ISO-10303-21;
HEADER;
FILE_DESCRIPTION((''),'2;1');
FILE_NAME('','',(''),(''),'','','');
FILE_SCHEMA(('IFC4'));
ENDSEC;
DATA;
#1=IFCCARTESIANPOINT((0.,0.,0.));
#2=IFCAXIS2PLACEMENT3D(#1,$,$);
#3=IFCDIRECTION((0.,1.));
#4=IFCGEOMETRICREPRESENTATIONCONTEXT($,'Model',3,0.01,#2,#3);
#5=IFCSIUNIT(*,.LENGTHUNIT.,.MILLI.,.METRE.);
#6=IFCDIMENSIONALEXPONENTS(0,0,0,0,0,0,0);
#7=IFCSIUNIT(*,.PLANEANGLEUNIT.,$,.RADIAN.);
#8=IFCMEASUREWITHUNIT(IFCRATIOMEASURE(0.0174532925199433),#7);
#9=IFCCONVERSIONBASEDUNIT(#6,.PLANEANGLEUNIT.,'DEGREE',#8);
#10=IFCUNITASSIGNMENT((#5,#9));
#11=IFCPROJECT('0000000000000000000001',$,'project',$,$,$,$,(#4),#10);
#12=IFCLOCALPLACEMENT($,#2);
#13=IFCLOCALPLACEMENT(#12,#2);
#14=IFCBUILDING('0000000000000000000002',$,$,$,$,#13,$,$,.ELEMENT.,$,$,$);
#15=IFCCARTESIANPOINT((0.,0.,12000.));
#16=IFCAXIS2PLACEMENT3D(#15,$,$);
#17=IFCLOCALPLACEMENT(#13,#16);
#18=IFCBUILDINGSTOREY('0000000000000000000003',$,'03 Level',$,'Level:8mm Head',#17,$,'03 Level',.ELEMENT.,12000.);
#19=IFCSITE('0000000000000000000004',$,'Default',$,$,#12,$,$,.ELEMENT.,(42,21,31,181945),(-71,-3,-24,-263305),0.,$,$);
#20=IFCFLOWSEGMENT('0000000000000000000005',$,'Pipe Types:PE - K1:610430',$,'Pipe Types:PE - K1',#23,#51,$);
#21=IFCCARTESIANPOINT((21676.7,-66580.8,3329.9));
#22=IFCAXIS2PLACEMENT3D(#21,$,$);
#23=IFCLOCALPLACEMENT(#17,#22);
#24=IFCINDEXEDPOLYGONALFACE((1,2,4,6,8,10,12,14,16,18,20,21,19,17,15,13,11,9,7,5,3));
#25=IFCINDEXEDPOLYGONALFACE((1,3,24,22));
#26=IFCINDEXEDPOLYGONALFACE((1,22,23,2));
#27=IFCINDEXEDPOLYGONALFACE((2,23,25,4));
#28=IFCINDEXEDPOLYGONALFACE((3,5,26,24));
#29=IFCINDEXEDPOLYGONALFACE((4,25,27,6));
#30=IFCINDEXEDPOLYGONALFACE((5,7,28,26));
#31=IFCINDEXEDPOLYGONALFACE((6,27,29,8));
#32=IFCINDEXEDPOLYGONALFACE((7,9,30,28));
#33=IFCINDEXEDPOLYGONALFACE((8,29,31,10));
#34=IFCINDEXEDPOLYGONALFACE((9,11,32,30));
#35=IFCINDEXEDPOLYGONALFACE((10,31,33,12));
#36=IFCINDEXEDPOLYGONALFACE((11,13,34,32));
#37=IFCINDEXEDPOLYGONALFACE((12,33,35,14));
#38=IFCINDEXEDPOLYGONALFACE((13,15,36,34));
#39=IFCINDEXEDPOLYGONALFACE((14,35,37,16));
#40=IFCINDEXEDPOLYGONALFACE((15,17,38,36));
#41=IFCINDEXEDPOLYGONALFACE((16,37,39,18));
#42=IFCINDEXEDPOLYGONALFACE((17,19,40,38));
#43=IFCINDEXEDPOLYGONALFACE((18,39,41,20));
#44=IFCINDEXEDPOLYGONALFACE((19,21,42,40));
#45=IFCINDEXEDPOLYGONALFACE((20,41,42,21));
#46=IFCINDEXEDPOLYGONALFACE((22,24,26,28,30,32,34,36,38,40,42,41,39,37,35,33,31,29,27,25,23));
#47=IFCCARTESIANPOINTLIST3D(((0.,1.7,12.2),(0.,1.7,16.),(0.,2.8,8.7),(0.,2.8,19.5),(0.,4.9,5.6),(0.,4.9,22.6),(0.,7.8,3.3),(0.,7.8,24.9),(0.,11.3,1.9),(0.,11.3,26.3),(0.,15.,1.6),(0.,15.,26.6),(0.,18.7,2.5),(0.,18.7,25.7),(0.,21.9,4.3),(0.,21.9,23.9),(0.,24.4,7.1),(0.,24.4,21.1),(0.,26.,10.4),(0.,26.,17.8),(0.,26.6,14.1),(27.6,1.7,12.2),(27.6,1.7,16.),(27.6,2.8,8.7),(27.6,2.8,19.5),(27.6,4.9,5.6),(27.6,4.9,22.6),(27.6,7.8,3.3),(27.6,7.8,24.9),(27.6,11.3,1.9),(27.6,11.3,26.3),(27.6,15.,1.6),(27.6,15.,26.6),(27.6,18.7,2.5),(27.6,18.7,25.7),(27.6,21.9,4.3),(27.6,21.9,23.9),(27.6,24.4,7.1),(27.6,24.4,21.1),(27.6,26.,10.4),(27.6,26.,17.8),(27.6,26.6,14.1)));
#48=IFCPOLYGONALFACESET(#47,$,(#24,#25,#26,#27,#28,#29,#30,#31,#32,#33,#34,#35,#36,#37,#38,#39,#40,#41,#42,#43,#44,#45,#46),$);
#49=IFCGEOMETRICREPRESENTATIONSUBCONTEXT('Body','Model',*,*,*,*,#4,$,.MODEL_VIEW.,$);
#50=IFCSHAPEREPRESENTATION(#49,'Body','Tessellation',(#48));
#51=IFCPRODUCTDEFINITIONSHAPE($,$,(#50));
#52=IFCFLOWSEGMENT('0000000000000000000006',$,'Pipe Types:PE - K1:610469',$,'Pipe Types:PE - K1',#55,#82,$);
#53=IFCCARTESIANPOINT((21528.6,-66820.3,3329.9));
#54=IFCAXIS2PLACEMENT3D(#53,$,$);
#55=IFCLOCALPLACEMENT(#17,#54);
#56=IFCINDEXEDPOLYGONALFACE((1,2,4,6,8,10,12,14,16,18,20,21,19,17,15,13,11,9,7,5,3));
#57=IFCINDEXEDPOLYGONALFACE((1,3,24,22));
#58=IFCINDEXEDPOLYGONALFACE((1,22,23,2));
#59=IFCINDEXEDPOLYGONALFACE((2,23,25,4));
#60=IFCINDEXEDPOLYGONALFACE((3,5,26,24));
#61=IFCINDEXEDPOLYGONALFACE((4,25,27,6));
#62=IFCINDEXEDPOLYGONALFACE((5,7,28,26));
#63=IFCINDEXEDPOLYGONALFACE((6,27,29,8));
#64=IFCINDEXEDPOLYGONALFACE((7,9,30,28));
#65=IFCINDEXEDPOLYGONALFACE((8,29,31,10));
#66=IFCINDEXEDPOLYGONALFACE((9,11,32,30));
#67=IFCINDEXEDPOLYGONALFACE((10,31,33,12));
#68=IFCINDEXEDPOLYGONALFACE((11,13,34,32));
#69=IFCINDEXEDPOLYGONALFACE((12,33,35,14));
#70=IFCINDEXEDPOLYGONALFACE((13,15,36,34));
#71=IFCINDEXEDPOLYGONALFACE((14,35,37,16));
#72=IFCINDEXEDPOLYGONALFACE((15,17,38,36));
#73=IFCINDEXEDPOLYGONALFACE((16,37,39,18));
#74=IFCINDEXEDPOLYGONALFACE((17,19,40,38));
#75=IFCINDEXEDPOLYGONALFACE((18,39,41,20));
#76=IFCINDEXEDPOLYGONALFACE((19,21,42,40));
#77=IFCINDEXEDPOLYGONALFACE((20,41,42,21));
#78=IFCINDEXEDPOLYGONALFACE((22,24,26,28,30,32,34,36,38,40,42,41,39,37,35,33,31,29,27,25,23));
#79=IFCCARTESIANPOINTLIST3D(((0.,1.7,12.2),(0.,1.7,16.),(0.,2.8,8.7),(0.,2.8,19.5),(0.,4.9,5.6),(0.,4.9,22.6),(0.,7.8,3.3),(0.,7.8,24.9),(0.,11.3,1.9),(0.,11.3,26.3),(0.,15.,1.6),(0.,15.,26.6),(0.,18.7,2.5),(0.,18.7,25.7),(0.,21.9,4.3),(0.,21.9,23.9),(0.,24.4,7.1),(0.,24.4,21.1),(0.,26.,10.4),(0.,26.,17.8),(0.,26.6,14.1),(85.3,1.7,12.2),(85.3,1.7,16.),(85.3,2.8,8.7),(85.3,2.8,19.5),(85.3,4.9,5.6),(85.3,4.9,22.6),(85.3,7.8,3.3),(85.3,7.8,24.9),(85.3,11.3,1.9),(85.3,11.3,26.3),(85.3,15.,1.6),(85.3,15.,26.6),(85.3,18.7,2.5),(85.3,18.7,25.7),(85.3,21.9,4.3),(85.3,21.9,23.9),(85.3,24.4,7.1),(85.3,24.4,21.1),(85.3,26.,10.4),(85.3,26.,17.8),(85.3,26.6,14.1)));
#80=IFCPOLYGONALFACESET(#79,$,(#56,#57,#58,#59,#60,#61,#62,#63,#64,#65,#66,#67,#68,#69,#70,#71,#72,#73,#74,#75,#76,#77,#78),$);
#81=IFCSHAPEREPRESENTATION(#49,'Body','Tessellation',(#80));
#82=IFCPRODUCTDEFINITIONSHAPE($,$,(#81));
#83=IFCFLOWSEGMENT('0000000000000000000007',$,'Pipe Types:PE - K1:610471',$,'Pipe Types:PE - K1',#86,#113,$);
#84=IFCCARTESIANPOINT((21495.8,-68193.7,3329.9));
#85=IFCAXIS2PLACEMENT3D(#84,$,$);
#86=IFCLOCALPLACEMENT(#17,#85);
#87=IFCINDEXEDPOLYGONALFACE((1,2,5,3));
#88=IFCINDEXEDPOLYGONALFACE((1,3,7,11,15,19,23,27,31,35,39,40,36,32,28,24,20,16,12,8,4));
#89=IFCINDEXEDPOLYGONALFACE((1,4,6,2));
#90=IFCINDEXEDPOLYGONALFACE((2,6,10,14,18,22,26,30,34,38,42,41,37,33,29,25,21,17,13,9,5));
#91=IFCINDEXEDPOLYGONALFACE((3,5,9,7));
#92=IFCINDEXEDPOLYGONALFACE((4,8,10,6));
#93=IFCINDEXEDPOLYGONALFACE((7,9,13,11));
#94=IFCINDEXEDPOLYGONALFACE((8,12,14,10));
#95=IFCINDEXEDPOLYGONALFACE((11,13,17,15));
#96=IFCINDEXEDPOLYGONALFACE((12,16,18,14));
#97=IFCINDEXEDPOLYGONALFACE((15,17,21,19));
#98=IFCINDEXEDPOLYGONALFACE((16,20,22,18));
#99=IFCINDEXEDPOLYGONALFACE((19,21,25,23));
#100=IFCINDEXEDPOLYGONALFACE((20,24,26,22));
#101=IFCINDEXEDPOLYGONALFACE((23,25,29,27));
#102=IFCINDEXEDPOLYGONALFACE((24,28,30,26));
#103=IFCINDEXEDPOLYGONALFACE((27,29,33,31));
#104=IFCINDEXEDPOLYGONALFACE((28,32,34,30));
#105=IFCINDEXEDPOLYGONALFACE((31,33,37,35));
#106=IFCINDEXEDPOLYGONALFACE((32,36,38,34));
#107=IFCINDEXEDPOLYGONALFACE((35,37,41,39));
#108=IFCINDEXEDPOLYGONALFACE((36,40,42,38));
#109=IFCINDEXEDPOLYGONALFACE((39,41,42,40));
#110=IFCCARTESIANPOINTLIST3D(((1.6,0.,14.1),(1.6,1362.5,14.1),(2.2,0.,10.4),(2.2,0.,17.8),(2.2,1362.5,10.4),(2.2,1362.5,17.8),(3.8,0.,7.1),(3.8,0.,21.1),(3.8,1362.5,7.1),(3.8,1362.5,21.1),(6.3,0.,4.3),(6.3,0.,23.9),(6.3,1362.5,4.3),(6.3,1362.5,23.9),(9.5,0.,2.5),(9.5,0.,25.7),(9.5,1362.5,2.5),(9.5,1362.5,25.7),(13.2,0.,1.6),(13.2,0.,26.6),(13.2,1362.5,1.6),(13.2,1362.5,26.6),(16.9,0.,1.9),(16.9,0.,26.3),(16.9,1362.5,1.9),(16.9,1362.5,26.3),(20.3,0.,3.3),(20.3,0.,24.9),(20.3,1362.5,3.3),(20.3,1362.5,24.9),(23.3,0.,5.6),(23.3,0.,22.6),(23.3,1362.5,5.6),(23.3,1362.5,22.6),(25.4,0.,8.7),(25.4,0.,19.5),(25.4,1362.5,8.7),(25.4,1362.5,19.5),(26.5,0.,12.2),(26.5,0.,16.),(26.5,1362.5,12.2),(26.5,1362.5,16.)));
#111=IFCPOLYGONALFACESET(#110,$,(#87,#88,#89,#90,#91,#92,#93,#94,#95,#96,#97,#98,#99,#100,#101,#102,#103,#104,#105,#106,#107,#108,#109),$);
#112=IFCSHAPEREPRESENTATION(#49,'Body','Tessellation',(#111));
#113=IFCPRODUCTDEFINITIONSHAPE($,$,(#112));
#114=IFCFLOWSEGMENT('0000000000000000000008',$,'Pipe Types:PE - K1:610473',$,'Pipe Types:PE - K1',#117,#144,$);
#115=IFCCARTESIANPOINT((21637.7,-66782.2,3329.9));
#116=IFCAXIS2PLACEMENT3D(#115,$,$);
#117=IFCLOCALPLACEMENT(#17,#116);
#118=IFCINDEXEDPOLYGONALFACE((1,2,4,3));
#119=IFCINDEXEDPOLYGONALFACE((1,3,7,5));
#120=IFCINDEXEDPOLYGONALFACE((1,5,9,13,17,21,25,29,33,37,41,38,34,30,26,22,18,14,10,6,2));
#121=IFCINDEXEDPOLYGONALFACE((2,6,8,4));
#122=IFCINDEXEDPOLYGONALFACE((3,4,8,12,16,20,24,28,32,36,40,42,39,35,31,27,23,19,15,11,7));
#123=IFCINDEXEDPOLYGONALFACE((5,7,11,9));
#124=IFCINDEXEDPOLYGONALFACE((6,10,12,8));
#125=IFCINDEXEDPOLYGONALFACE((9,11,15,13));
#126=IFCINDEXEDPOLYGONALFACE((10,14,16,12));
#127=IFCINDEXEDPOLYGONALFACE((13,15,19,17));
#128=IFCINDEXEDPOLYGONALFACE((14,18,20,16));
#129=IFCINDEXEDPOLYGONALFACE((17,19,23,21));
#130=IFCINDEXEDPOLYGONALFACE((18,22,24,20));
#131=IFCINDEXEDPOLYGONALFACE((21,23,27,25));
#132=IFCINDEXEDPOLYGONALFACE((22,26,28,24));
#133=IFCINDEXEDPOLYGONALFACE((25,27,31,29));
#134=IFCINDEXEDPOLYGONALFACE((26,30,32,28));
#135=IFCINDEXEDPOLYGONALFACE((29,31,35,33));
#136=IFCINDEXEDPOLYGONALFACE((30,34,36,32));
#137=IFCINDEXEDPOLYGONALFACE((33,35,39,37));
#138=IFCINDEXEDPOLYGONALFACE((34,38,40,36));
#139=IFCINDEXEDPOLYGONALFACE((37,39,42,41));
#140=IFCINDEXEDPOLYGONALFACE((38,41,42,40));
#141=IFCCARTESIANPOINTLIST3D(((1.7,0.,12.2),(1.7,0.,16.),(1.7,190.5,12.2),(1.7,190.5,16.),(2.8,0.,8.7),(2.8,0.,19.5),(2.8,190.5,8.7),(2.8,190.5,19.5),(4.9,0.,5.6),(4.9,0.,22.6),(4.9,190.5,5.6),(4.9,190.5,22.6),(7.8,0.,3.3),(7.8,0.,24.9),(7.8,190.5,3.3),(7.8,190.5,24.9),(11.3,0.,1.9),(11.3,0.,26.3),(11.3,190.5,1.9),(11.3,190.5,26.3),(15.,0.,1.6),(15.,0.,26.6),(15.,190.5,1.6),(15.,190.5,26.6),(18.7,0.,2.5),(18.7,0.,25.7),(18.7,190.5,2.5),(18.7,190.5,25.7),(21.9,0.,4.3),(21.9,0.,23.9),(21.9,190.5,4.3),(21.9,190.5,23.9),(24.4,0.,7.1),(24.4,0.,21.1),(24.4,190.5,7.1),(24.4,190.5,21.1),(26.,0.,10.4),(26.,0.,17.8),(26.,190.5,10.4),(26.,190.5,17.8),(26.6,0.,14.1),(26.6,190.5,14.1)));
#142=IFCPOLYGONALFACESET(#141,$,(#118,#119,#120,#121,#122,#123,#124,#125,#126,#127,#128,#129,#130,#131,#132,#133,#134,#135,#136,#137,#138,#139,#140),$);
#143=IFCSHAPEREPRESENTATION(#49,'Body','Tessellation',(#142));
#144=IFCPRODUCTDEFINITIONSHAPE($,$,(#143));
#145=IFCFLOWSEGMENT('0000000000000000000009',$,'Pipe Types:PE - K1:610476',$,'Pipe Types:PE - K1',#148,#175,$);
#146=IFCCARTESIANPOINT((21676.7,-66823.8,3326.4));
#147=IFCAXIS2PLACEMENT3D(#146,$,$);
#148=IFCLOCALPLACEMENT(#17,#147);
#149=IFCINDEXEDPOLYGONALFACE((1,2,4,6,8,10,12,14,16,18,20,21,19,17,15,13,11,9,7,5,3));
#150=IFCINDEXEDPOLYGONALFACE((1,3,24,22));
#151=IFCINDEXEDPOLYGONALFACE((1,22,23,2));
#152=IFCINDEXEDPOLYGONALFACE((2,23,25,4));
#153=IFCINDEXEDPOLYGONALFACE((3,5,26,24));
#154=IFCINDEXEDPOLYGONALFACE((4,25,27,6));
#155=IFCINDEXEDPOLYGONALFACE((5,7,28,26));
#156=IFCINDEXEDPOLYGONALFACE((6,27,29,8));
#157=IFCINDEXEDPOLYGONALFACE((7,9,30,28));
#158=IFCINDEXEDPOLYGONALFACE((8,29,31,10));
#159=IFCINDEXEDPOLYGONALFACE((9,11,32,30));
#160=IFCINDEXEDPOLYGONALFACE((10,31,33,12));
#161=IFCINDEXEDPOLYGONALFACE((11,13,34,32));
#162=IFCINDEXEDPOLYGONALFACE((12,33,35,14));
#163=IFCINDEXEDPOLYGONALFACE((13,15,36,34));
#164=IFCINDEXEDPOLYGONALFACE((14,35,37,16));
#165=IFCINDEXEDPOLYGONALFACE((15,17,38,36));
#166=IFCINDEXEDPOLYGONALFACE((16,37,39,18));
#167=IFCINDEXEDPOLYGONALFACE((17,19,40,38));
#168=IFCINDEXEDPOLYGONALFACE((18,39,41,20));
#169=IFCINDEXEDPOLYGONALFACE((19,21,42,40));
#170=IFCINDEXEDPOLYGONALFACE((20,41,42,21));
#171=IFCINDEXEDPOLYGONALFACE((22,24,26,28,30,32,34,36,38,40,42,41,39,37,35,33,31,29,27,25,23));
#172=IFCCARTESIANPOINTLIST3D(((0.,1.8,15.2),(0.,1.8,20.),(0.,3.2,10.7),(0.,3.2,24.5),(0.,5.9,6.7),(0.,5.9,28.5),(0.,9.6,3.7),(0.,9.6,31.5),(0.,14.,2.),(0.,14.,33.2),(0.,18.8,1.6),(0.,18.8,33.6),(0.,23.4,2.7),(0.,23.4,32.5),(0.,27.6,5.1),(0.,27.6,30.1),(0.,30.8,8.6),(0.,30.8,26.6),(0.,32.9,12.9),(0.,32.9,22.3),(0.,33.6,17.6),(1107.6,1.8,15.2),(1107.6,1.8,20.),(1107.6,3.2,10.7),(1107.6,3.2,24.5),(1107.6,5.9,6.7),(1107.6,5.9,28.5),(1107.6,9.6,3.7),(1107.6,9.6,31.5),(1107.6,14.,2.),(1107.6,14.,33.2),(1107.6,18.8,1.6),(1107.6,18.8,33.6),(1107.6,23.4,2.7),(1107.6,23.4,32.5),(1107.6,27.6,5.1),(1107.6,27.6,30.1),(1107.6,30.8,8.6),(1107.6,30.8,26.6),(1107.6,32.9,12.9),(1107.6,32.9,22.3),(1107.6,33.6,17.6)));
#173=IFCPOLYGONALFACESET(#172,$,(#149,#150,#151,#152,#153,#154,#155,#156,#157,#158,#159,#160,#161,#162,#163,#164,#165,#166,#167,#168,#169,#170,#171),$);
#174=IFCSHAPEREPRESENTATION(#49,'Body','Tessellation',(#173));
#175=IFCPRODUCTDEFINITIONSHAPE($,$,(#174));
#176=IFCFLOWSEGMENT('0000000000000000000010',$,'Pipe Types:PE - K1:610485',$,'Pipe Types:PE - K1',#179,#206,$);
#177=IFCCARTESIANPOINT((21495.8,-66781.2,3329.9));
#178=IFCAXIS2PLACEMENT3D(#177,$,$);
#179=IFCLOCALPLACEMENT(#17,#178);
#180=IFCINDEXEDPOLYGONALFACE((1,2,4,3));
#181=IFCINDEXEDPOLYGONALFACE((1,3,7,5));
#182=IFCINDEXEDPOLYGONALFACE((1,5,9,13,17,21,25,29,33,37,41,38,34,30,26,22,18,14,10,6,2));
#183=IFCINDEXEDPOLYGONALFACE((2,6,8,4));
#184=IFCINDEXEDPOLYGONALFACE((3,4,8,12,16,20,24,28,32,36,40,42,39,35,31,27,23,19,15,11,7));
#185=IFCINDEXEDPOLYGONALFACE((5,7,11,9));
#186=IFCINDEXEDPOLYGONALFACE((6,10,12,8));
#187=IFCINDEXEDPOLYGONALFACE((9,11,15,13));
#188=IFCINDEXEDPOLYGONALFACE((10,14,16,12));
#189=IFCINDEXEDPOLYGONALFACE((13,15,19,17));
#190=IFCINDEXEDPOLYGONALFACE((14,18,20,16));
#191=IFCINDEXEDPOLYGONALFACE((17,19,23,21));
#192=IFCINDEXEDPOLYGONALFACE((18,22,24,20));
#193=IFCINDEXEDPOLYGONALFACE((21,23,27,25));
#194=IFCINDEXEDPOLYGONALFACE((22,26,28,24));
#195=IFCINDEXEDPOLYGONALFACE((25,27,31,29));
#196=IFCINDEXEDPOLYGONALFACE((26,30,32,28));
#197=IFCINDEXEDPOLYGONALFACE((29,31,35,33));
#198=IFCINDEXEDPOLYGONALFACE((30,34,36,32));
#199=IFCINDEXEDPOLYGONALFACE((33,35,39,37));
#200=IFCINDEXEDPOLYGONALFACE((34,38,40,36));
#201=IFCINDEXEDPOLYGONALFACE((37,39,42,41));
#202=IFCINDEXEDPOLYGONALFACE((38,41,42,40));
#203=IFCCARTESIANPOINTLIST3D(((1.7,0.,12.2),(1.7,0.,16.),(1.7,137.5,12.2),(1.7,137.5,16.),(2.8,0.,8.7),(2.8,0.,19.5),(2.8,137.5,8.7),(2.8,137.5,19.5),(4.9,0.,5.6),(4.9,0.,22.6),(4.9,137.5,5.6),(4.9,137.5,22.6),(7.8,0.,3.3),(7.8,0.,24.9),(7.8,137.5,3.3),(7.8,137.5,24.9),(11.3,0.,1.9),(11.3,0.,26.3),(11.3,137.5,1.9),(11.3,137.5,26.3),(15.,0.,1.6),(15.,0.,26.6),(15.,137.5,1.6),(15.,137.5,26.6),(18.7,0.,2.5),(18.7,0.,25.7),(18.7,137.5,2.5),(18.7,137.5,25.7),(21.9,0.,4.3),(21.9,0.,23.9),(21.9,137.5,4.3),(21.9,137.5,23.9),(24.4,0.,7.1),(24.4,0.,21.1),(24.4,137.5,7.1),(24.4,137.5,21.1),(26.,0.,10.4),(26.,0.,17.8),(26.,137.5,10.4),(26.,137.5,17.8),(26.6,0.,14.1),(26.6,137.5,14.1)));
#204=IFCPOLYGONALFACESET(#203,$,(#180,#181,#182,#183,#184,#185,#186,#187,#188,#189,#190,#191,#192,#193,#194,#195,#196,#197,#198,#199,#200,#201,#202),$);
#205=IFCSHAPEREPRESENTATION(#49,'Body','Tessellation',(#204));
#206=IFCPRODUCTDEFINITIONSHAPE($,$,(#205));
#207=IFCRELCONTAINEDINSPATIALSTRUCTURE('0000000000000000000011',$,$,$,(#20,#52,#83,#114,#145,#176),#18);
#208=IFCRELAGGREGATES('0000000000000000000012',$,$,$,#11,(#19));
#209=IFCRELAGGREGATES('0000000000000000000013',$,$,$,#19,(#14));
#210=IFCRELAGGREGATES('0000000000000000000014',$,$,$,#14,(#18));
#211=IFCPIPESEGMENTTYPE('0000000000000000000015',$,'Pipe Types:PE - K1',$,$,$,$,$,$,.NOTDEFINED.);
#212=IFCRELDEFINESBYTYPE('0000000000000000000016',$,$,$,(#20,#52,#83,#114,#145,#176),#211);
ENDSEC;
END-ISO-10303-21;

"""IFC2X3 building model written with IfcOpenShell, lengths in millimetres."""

from ifc_helpers import new_model, entity, si_unit, converted_unit, direction, frame, frame_2d, origin, origin_2d_with_axis, place, context, subcontext, project, spatial, circle, extrude, type_object, element, save


model = new_model("IFC2X3")

# Units and contexts
model_context = context("Model", 3, precision=0.01, world=origin(), true_north=direction((0.0, 1.0)))
body_context = subcontext(model_context, "Body", "Model", "MODEL_VIEW")
ifc_project = project(units=[si_unit("LENGTHUNIT", "METRE", prefix="MILLI"), converted_unit("PLANEANGLEUNIT", "DEGREE", entity("IfcRatioMeasure", 0.0174532925199433), si_unit("PLANEANGLEUNIT", "RADIAN"), dimensions=[0, 0, 0, 0, 0, 0, 0])], contexts=[model_context])

# Site, building, storey
site_placement = place(None, origin())
site = spatial("IfcSite", under=ifc_project, at=site_placement, Name="Default", CompositionType="ELEMENT", RefLatitude=(42, 21, 31, 181945), RefLongitude=(-71, -3, -24, -263305), RefElevation=0.0)
building_placement = place(site_placement, origin())
building = spatial("IfcBuilding", under=site, at=building_placement, CompositionType="ELEMENT")
storey_placement = place(building_placement, frame((0.0, 0.0, 12000.0)))
storey = spatial("IfcBuildingStorey", under=building, at=storey_placement, Name="03 Level", ObjectType="Level:8mm Head", LongName="03 Level", CompositionType="ELEMENT", Elevation=12000.0)

# Flow segments
pipe_segment_type = type_object("IfcPipeSegmentType", Name="Pipe Types:PE - K1", PredefinedType="NOTDEFINED")
flow_segment_1_placement = place(storey_placement, frame((21676.7, -66580.8, 3329.9)))
element("IfcFlowSegment", 1, at=flow_segment_1_placement, inside=storey, type_object=pipe_segment_type, Name="Pipe Types:PE - K1:610430", ObjectType="Pipe Types:PE - K1", context=body_context, shape_type="SweptSolid", body=[
    extrude(circle(Radius=12.5, at=frame_2d((0.0, 0.0), x_axis=(1.0, 0.0))), frame((0.0, 14.1, 14.1), z_axis=(1.0, 0.0, 0.0), x_axis=(0.0, 1.0, 0.0)), (0.0, 0.0, 1.0), 27.6),
])
flow_segment_2_placement = place(storey_placement, frame((21528.6, -66820.3, 3329.9)))
element("IfcFlowSegment", 2, at=flow_segment_2_placement, inside=storey, type_object=pipe_segment_type, Name="Pipe Types:PE - K1:610469", ObjectType="Pipe Types:PE - K1", context=body_context, shape_type="SweptSolid", body=[
    extrude(circle(Radius=12.5, at=origin_2d_with_axis()), frame((0.0, 14.1, 14.1), z_axis=(1.0, 0.0, 0.0), x_axis=(0.0, 1.0, 0.0)), (0.0, 0.0, 1.0), 85.3),
])
flow_segment_3_placement = place(storey_placement, frame((21495.8, -68193.7, 3329.9)))
element("IfcFlowSegment", 3, at=flow_segment_3_placement, inside=storey, type_object=pipe_segment_type, Name="Pipe Types:PE - K1:610471", ObjectType="Pipe Types:PE - K1", context=body_context, shape_type="SweptSolid", body=[
    extrude(circle(Radius=12.5, at=frame_2d((0.0, 0.0), x_axis=(1.0, 0.0))), frame((14.1, 0.0, 14.1), z_axis=(0.0, 1.0, 0.0), x_axis=(-1.0, 0.0, 0.0)), (0.0, 0.0, 1.0), 1362.5),
])
flow_segment_4_placement = place(storey_placement, frame((21637.7, -66782.2, 3329.9)))
element("IfcFlowSegment", 4, at=flow_segment_4_placement, inside=storey, type_object=pipe_segment_type, Name="Pipe Types:PE - K1:610473", ObjectType="Pipe Types:PE - K1", context=body_context, shape_type="SweptSolid", body=[
    extrude(circle(Radius=12.5, at=origin_2d_with_axis()), frame((14.1, 0.0, 14.1), z_axis=(0.0, 1.0, 0.0), x_axis=(1.0, 0.0, 0.0)), (0.0, 0.0, 1.0), 190.5),
])
flow_segment_5_placement = place(storey_placement, frame((21676.7, -66823.8, 3326.4)))
element("IfcFlowSegment", 5, at=flow_segment_5_placement, inside=storey, type_object=pipe_segment_type, Name="Pipe Types:PE - K1:610476", ObjectType="Pipe Types:PE - K1", context=body_context, shape_type="SweptSolid", body=[
    extrude(circle(Radius=16.0, at=frame_2d((0.0, 0.0), x_axis=(1.0, 0.0))), frame((0.0, 17.6, 17.6), z_axis=(1.0, 0.0, 0.0), x_axis=(0.0, 1.0, 0.0)), (0.0, 0.0, 1.0), 1107.6),
])
flow_segment_6_placement = place(storey_placement, frame((21495.8, -66781.2, 3329.9)))
element("IfcFlowSegment", 6, at=flow_segment_6_placement, inside=storey, type_object=pipe_segment_type, Name="Pipe Types:PE - K1:610485", ObjectType="Pipe Types:PE - K1", context=body_context, shape_type="SweptSolid", body=[
    extrude(circle(Radius=12.5, at=frame_2d((0.0, 0.0), x_axis=(1.0, 0.0))), frame((14.1, 0.0, 14.1), z_axis=(0.0, 1.0, 0.0), x_axis=(1.0, 0.0, 0.0)), (0.0, 0.0, 1.0), 137.5),
])

save(model, "model.ifc")
